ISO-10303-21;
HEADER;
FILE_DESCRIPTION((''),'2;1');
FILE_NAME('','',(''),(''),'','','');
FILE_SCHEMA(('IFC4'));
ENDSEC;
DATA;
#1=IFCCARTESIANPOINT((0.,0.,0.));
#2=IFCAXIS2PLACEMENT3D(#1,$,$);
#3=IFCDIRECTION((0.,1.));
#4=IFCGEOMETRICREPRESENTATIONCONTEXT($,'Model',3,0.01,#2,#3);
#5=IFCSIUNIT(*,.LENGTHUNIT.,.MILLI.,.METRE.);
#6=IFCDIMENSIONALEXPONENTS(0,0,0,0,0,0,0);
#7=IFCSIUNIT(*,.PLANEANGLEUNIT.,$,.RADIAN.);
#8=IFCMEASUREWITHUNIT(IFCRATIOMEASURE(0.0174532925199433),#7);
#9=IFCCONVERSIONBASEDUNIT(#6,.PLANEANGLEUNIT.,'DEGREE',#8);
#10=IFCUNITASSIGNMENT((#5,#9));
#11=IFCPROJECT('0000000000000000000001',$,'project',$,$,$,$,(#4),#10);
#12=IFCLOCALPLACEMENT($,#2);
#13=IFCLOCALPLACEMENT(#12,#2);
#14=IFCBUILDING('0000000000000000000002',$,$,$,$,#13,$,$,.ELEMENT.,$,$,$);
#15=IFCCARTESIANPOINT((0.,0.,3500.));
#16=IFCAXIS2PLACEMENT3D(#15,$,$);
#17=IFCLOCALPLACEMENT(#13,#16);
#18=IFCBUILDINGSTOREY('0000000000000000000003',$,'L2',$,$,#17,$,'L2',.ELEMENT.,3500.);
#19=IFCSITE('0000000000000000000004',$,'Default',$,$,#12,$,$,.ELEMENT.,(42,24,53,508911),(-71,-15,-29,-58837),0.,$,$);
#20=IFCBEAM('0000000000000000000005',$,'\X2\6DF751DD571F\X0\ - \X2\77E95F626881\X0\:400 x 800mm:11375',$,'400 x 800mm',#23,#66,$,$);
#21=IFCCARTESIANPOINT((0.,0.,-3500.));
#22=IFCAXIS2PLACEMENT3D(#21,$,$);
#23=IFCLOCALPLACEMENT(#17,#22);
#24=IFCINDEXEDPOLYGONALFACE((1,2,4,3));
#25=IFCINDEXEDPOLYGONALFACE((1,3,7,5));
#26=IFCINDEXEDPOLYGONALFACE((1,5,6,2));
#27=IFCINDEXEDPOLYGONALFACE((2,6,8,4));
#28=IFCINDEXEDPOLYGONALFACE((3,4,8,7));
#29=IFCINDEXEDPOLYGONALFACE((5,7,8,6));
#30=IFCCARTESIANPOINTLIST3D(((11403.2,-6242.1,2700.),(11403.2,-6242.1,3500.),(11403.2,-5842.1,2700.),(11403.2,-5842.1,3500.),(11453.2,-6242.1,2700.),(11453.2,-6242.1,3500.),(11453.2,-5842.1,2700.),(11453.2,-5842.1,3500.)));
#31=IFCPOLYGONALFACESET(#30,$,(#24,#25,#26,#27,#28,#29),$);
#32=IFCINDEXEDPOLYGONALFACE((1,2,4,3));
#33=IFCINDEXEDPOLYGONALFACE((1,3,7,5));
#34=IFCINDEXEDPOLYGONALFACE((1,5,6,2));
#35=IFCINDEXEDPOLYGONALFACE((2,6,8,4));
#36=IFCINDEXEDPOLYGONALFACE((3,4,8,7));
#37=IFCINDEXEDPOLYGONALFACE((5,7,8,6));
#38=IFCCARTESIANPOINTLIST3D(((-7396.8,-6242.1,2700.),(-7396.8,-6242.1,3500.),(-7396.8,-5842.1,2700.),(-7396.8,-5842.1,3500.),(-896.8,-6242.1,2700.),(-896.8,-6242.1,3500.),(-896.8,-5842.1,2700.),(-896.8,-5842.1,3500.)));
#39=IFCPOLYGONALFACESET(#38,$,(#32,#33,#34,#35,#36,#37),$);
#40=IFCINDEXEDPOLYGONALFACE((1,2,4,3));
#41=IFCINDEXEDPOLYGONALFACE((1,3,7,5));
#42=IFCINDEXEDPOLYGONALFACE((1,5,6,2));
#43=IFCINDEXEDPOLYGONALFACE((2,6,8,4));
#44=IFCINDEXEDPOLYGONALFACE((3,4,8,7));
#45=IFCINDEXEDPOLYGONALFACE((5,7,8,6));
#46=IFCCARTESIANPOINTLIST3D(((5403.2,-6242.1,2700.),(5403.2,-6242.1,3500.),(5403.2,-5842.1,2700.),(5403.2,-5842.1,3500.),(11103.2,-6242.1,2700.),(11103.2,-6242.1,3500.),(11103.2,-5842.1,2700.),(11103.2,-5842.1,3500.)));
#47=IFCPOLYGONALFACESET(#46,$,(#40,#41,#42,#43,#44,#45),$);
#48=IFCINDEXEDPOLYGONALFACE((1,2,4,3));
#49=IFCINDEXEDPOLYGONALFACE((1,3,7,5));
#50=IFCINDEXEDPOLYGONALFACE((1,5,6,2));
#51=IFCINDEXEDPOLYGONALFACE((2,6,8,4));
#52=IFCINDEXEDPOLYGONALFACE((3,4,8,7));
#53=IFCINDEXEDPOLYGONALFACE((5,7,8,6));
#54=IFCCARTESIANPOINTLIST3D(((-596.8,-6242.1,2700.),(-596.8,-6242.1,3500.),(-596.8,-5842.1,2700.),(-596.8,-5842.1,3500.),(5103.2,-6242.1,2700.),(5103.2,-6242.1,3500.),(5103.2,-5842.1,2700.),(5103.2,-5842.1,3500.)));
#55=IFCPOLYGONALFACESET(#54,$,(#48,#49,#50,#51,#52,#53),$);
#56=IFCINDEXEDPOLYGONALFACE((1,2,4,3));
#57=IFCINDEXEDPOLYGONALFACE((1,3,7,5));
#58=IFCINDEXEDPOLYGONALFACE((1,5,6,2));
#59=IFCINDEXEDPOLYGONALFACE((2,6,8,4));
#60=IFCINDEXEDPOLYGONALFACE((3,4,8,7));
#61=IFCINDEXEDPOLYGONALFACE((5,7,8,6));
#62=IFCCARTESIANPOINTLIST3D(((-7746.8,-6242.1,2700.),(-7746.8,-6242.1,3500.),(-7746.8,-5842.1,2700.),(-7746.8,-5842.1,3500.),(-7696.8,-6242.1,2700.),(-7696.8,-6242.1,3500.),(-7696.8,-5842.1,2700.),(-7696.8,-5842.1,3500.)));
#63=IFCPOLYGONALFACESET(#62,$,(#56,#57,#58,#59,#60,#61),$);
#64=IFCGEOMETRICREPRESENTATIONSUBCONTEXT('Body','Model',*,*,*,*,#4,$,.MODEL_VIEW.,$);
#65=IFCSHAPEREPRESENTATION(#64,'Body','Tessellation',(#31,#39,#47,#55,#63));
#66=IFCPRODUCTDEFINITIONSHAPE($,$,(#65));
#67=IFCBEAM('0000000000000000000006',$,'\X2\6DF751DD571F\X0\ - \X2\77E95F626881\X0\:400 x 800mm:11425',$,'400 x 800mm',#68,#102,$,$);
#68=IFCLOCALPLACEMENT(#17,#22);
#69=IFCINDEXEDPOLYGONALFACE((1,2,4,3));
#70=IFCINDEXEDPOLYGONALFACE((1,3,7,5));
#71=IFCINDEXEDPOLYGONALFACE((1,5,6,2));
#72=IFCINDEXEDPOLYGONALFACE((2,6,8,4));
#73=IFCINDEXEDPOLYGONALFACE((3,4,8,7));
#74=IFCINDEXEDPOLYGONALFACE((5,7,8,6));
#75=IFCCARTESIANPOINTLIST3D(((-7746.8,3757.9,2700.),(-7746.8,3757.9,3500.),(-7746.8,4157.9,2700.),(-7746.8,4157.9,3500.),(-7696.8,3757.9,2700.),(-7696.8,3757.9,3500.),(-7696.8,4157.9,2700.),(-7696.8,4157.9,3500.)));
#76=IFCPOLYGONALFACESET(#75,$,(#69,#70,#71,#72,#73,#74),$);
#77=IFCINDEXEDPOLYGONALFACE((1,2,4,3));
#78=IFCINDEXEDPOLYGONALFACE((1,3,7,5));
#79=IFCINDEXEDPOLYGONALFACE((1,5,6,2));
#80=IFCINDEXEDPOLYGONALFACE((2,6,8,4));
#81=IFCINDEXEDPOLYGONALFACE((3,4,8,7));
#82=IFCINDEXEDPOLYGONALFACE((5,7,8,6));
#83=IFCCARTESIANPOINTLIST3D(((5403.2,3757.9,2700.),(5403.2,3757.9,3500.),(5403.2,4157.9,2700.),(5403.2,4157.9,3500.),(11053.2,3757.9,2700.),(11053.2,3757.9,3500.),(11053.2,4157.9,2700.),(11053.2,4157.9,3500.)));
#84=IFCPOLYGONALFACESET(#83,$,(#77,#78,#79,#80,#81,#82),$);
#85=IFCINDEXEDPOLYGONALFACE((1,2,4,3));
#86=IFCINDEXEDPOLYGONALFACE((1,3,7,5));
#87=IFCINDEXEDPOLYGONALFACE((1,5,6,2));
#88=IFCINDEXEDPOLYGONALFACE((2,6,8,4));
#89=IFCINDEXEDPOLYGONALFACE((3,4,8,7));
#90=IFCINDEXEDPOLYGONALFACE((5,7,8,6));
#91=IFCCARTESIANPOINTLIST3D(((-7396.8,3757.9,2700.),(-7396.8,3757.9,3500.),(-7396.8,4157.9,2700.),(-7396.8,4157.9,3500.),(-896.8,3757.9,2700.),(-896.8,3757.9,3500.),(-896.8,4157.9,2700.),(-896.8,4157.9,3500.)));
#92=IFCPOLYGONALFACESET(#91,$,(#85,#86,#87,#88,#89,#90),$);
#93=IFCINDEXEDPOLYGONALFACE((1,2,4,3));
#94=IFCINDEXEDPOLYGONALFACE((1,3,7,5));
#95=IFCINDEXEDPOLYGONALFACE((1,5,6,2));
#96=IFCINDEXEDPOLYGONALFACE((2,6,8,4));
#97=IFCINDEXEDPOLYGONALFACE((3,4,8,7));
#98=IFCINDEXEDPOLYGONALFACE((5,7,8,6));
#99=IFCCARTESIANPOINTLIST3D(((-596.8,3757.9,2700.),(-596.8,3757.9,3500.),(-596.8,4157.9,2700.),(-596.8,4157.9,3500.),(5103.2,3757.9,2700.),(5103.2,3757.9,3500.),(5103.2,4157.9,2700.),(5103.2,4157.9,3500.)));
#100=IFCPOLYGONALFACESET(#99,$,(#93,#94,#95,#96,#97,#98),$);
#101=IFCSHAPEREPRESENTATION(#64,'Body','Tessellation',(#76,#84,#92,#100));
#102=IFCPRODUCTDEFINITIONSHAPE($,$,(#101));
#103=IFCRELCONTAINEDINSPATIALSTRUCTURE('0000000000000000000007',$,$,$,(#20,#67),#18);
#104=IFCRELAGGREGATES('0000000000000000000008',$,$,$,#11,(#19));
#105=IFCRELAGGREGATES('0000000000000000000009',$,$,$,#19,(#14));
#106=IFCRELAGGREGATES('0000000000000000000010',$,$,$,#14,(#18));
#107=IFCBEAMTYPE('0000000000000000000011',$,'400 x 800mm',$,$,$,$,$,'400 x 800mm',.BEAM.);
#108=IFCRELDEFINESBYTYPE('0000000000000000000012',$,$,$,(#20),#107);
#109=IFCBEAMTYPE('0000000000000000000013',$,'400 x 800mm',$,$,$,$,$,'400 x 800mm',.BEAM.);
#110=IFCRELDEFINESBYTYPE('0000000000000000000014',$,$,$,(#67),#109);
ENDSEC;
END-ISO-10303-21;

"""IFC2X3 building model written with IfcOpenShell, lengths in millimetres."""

from ifc_helpers import new_model, entity, si_unit, converted_unit, direction, frame, frame_2d, origin, place, context, subcontext, project, spatial, rectangle, extrude, source, transform, mapped, type_object, type_shapes, element, save


model = new_model("IFC2X3")

# Units and contexts
model_context = context("Model", 3, precision=0.01, world=origin(), true_north=direction((0.0, 1.0)))
body_context = subcontext(model_context, "Body", "Model", "MODEL_VIEW")
ifc_project = project(units=[si_unit("LENGTHUNIT", "METRE", prefix="MILLI"), converted_unit("PLANEANGLEUNIT", "DEGREE", entity("IfcRatioMeasure", 0.0174532925199433), si_unit("PLANEANGLEUNIT", "RADIAN"), dimensions=[0, 0, 0, 0, 0, 0, 0])], contexts=[model_context])

# Site, building, storey
site_placement = place(None, origin())
site = spatial("IfcSite", under=ifc_project, at=site_placement, Name="Default", CompositionType="ELEMENT", RefLatitude=(42, 24, 53, 508911), RefLongitude=(-71, -15, -29, -58837), RefElevation=0.0)
building_placement = place(site_placement, origin())
building = spatial("IfcBuilding", under=site, at=building_placement, CompositionType="ELEMENT")
storey_placement = place(building_placement, frame((0.0, 0.0, 3500.0)))
storey = spatial("IfcBuildingStorey", under=building, at=storey_placement, Name="L2", LongName="L2", CompositionType="ELEMENT", Elevation=3500.0)

# Beams
beam_type_1 = type_object("IfcBeamType", Name="400 x 800mm", ElementType="400 x 800mm", PredefinedType="BEAM")
shared_shape_1 = source(origin(), body_context, "Body", "SweptSolid", [
    extrude(rectangle(XDim=50.0, YDim=400.0, at=frame_2d((0.0, 0.0), x_axis=(1.0, 0.0))), frame((11428.2, -6042.1, 2700.0), z_axis=(0.0, 0.0, 1.0), x_axis=(-1.0, 0.0, 0.0)), (0.0, 0.0, 1.0), 800.0),
    extrude(rectangle(XDim=6500.0, YDim=400.0, at=frame_2d((640.0, -40.0), x_axis=(1.0, 0.0))), frame((-4786.8, -6002.1, 2700.0)), (0.0, 0.0, 1.0), 800.0),
    extrude(rectangle(XDim=5700.0, YDim=400.0, at=frame_2d((560.0, 40.0), x_axis=(1.0, 0.0))), frame((8813.2, -6002.1, 2700.0), z_axis=(0.0, 0.0, 1.0), x_axis=(-1.0, 0.0, 0.0)), (0.0, 0.0, 1.0), 800.0),
    extrude(rectangle(XDim=5700.0, YDim=400.0, at=frame_2d((0.0, 0.0), x_axis=(1.0, 0.0))), frame((2253.2, -6042.1, 2700.0)), (0.0, 0.0, 1.0), 800.0),
    extrude(rectangle(XDim=50.0, YDim=400.0, at=frame_2d((0.0, 0.0), x_axis=(1.0, 0.0))), frame((-7721.8, -6042.1, 2700.0)), (0.0, 0.0, 1.0), 800.0),
])
type_shapes(beam_type_1, [shared_shape_1])
beam_1_placement = place(storey_placement, frame((0.0, 0.0, -3500.0)))
element("IfcBeam", 1, at=beam_1_placement, inside=storey, type_object=beam_type_1, Name="混凝土 - 矩形梁:400 x 800mm:11375", ObjectType="400 x 800mm", context=body_context, shape_type="MappedRepresentation", body=[
    mapped(shared_shape_1, transform((0.0, 0.0, 0.0), scale=1.0)),
])
beam_type_2 = type_object("IfcBeamType", Name="400 x 800mm", ElementType="400 x 800mm", PredefinedType="BEAM")
shared_shape_2 = source(origin(), body_context, "Body", "SweptSolid", [
    extrude(rectangle(XDim=50.0, YDim=400.0, at=frame_2d((0.0, 0.0), x_axis=(1.0, 0.0))), frame((-7721.8, 3957.9, 2700.0)), (0.0, 0.0, 1.0), 800.0),
    extrude(rectangle(XDim=5650.0, YDim=400.0, at=frame_2d((0.0, 0.0), x_axis=(1.0, 0.0))), frame((8228.2, 3957.9, 2700.0), z_axis=(0.0, 0.0, 1.0), x_axis=(-1.0, 0.0, 0.0)), (0.0, 0.0, 1.0), 800.0),
    extrude(rectangle(XDim=6500.0, YDim=400.0, at=frame_2d((640.0, 40.0), x_axis=(1.0, 0.0))), frame((-4786.8, 3917.9, 2700.0)), (0.0, 0.0, 1.0), 800.0),
    extrude(rectangle(XDim=5700.0, YDim=400.0, at=frame_2d((0.0, 0.0), x_axis=(1.0, 0.0))), frame((2253.2, 3957.9, 2700.0), z_axis=(0.0, 0.0, 1.0), x_axis=(-1.0, 0.0, 0.0)), (0.0, 0.0, 1.0), 800.0),
])
type_shapes(beam_type_2, [shared_shape_2])
beam_2_placement = place(storey_placement, frame((0.0, 0.0, -3500.0)))
element("IfcBeam", 2, at=beam_2_placement, inside=storey, type_object=beam_type_2, Name="混凝土 - 矩形梁:400 x 800mm:11425", ObjectType="400 x 800mm", context=body_context, shape_type="MappedRepresentation", body=[
    mapped(shared_shape_2, transform((0.0, 0.0, 0.0), scale=1.0)),
])

save(model, "model.ifc")
